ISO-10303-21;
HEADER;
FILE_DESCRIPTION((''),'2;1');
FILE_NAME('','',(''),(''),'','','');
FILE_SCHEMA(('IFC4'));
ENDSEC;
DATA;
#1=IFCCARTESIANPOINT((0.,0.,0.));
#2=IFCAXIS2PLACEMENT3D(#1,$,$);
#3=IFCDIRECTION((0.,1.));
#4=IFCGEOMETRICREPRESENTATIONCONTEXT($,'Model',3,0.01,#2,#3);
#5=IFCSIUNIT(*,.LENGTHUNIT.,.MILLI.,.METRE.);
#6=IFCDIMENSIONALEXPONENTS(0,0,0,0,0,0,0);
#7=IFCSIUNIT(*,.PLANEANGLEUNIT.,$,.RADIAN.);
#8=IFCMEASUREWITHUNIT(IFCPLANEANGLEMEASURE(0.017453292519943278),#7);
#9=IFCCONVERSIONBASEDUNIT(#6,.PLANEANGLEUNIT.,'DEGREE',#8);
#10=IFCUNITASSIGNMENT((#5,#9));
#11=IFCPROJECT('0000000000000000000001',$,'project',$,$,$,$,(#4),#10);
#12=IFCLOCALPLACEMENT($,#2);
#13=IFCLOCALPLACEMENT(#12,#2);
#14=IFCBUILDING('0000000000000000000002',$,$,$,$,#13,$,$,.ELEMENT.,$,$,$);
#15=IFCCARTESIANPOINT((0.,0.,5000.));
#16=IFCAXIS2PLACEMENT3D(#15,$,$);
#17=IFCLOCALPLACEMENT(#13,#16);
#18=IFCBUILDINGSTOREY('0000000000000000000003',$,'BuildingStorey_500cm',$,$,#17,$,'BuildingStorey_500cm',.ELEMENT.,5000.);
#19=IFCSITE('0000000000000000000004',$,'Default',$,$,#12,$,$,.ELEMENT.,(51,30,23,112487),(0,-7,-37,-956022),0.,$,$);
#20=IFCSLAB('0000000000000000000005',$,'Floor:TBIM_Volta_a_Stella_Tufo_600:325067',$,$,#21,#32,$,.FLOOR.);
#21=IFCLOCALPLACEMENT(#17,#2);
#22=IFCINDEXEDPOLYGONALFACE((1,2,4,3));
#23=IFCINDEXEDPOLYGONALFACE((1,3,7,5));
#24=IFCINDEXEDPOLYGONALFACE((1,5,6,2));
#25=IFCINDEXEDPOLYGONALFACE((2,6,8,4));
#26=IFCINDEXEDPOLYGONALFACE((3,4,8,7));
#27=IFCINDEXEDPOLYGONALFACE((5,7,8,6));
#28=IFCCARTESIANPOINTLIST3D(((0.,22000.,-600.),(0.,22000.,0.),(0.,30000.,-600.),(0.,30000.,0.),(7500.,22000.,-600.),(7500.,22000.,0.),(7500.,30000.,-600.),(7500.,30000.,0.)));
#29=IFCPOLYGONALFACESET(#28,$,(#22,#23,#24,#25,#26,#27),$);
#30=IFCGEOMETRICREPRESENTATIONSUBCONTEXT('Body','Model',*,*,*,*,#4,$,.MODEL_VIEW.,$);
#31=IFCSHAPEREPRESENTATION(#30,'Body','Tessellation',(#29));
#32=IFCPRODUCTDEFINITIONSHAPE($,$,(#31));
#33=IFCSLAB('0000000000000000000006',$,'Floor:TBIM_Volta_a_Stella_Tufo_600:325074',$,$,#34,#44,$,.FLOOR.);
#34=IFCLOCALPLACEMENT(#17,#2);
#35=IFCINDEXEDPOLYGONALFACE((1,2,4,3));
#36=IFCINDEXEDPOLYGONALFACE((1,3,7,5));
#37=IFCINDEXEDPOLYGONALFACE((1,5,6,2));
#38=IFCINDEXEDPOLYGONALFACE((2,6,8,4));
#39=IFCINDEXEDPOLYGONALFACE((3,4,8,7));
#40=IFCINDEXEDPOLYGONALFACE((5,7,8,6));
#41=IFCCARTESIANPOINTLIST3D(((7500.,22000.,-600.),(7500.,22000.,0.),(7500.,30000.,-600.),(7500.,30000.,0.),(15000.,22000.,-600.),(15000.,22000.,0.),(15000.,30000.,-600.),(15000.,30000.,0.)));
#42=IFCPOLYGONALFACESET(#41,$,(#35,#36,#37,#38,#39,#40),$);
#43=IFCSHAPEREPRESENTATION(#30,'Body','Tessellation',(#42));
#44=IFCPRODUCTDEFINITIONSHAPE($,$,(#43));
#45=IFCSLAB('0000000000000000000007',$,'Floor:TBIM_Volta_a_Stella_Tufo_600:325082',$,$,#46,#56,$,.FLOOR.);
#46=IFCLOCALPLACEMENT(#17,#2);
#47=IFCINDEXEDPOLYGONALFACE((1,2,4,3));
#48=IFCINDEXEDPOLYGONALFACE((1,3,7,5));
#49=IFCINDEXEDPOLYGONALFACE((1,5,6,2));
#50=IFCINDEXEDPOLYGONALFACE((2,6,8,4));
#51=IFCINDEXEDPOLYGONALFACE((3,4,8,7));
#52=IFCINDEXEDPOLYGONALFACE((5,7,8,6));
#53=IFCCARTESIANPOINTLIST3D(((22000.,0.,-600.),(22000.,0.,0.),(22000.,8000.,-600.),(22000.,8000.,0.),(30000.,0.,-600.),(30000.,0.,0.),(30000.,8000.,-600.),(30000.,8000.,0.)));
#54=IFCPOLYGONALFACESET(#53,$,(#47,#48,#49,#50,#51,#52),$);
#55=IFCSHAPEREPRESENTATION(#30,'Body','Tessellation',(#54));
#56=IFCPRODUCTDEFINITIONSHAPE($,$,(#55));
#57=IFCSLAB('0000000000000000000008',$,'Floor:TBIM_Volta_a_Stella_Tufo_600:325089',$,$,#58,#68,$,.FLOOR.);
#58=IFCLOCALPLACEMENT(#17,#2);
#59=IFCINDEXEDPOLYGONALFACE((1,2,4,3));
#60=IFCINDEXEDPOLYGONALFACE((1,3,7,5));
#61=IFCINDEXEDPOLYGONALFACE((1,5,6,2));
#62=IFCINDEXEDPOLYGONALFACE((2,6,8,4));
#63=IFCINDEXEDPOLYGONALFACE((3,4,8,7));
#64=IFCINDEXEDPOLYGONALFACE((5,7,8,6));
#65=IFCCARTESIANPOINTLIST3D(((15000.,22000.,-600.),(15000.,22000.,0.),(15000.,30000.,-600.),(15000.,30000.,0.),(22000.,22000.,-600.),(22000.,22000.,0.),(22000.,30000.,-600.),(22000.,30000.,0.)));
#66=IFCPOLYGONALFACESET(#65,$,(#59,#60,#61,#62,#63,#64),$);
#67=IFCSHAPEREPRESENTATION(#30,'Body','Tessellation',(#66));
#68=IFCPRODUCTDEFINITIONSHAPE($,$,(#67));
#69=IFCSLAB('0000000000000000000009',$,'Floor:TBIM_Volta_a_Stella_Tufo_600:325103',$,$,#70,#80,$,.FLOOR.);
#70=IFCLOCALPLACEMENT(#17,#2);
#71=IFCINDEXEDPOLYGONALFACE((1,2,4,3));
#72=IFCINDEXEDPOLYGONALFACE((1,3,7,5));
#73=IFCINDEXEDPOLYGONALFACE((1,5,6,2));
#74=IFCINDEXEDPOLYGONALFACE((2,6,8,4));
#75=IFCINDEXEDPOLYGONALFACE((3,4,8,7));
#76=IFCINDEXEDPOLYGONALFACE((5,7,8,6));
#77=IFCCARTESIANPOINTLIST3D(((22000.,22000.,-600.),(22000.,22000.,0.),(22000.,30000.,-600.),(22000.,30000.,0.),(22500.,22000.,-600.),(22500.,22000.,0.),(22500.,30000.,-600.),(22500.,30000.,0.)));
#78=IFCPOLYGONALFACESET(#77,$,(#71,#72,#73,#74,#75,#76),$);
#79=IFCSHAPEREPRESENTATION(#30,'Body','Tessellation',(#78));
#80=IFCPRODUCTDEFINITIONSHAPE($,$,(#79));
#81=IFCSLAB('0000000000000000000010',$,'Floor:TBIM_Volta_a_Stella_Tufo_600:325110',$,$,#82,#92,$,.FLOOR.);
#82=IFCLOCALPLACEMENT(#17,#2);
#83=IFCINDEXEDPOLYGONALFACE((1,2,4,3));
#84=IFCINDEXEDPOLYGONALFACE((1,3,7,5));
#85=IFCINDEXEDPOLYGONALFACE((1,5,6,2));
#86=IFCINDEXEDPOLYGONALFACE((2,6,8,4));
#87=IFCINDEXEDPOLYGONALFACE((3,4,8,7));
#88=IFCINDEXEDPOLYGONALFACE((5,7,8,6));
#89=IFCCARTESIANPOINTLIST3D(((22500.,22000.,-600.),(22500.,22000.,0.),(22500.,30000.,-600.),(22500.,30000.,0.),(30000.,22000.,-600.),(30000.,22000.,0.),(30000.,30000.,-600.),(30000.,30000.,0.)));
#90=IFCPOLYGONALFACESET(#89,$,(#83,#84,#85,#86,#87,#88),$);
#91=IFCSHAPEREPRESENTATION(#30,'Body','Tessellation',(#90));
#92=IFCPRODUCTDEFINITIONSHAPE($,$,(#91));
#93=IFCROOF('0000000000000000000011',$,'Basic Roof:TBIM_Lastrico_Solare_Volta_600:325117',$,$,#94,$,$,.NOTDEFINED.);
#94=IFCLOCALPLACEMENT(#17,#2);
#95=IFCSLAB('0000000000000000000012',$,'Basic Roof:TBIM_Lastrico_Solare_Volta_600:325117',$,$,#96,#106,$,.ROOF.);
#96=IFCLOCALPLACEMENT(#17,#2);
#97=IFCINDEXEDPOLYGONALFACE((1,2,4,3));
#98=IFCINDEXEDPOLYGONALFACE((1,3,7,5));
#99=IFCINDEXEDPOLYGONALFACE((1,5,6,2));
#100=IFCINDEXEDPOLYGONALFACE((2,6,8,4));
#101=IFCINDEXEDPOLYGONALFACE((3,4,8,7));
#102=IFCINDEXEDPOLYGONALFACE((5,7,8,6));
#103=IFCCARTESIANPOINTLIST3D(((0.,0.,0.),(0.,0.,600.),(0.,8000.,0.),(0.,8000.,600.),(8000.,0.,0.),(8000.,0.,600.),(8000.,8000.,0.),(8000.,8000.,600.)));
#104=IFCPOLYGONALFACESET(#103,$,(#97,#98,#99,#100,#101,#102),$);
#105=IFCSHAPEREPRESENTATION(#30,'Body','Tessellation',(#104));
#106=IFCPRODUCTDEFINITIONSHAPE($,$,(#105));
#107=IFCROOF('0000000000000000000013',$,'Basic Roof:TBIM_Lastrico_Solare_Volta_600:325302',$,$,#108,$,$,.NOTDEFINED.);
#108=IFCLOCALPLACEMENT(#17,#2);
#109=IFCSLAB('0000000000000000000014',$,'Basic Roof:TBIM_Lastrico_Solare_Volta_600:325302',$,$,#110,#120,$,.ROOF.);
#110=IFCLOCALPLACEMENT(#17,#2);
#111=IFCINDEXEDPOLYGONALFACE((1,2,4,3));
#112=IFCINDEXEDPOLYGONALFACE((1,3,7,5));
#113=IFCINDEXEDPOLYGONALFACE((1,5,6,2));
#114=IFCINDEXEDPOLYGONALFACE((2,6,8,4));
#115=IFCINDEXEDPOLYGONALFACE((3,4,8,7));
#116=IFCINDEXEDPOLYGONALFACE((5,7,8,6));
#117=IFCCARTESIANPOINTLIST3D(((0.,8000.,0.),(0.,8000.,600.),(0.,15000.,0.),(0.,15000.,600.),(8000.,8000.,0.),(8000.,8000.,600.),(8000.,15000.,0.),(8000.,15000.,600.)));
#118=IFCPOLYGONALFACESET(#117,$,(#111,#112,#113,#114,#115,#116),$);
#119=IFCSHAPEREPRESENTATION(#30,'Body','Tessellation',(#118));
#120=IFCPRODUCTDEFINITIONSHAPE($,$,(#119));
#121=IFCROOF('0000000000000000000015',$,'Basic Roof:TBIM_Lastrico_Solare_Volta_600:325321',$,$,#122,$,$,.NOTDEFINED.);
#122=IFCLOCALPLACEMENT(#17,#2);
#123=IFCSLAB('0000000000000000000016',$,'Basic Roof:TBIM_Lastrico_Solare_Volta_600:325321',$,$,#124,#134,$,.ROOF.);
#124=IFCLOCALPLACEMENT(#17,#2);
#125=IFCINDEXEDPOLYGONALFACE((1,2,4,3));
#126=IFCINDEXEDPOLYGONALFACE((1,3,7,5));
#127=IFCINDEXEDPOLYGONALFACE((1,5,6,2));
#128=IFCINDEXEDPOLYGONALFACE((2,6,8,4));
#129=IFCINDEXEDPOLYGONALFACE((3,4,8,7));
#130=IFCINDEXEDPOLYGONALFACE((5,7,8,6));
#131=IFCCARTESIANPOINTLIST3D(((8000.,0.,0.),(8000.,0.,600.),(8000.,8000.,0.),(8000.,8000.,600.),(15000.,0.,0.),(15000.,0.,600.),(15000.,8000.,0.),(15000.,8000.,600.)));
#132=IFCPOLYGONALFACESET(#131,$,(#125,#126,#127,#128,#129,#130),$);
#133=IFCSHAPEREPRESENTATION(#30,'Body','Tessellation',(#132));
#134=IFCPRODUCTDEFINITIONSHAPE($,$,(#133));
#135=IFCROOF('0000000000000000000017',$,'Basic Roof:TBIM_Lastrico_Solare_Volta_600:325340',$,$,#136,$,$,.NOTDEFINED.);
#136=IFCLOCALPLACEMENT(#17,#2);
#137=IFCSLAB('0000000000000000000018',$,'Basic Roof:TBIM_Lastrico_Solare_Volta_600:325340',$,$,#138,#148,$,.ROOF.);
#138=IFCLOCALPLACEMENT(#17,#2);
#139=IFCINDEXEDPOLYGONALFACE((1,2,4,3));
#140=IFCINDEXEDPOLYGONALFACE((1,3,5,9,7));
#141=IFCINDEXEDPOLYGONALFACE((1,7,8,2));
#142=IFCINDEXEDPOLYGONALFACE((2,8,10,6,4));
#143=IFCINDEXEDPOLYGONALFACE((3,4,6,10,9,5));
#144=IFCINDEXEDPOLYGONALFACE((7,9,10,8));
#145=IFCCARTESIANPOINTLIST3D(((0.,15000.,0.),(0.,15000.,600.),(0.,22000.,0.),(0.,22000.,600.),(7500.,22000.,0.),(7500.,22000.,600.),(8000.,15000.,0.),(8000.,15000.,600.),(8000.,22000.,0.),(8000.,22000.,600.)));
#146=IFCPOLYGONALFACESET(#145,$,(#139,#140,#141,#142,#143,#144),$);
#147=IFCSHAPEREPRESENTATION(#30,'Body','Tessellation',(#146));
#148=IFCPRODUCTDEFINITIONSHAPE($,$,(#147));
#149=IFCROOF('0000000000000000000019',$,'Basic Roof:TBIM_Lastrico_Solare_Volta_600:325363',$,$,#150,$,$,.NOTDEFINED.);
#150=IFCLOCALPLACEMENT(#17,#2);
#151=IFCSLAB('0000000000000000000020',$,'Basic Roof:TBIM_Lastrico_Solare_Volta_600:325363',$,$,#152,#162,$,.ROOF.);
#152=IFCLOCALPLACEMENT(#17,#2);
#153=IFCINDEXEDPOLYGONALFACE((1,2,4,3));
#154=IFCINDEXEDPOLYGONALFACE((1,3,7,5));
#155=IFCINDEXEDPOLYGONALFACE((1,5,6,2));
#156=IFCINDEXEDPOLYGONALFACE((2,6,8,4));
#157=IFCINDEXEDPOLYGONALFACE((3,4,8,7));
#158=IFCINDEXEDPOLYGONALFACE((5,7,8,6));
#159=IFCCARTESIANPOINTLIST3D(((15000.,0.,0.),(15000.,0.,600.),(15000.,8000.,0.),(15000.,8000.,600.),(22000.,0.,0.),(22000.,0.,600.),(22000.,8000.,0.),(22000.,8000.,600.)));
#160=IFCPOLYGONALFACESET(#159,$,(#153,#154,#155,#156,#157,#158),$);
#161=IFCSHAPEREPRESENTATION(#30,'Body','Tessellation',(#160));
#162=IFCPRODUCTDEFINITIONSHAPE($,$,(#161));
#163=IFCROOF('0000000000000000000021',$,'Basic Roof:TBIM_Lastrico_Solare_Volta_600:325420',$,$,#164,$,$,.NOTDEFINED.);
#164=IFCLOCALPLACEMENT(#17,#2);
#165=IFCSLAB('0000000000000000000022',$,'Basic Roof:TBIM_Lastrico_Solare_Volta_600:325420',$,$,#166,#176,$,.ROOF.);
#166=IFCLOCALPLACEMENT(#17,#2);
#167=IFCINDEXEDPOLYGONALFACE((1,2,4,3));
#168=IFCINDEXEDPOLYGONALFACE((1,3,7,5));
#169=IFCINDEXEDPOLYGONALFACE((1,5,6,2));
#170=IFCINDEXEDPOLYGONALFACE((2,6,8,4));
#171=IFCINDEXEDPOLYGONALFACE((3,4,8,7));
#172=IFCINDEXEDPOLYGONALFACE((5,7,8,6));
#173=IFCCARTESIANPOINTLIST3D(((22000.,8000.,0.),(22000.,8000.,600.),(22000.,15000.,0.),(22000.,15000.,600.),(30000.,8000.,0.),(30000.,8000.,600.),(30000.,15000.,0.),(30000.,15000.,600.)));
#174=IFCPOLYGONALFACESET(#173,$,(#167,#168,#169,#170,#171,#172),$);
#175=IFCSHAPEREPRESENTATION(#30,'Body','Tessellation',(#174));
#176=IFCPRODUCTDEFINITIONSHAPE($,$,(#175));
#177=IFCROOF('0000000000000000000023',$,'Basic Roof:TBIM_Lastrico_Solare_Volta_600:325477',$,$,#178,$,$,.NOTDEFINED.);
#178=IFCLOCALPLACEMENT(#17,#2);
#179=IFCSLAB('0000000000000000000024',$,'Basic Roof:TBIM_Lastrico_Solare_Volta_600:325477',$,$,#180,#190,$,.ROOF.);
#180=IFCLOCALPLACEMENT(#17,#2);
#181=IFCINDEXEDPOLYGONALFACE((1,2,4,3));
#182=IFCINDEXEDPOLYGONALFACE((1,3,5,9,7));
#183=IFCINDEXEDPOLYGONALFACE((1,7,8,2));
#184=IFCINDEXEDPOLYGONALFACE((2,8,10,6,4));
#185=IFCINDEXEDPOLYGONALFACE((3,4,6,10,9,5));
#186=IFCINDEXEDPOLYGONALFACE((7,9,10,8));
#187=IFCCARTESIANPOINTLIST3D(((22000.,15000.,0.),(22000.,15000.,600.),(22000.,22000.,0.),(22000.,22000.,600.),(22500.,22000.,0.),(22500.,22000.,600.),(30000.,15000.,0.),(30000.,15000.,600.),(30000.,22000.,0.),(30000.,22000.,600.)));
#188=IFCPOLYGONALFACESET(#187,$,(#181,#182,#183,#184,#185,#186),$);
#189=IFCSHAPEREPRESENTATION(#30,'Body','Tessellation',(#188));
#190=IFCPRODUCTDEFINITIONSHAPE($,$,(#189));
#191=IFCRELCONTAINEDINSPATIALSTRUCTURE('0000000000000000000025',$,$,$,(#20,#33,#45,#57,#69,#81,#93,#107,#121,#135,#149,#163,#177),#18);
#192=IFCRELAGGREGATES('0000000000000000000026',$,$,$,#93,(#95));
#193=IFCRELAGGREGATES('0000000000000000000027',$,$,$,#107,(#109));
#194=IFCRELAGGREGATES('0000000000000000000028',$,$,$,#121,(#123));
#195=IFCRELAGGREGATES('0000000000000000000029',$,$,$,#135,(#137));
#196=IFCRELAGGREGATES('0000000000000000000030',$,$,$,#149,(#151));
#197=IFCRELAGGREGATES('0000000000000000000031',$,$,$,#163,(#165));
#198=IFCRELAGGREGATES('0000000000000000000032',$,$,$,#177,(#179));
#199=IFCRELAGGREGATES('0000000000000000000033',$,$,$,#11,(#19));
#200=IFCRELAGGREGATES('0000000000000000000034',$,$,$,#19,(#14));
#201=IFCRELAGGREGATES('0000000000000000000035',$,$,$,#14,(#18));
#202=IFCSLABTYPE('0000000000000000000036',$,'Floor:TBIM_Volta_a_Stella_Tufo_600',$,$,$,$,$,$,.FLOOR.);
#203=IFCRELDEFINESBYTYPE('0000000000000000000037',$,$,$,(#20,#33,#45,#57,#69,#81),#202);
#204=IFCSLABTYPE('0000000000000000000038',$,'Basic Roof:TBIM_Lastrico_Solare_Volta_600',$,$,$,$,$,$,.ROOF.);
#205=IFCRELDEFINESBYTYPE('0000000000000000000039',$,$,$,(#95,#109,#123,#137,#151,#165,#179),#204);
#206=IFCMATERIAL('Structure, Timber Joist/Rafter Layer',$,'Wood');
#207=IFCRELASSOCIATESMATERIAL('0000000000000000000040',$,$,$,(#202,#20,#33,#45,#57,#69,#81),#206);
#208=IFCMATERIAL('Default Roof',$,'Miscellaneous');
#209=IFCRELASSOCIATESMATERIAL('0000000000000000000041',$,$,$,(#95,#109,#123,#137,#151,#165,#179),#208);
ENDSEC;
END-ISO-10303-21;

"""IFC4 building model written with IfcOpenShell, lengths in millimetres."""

from ifc_helpers import new_model, entity, si_unit, converted_unit, direction, frame, origin, place, context, subcontext, project, spatial, indexed_curve, outline, extrude, material, type_object, element, aggregate, save


model = new_model("IFC4")

# Units and contexts
model_context = context("Model", 3, precision=0.01, world=origin(), true_north=direction((0.0, 1.0)))
body_context = subcontext(model_context, "Body", "Model", "MODEL_VIEW")
ifc_project = project(units=[si_unit("LENGTHUNIT", "METRE", prefix="MILLI"), converted_unit("PLANEANGLEUNIT", "DEGREE", entity("IfcPlaneAngleMeasure", 0.017453292519943278), si_unit("PLANEANGLEUNIT", "RADIAN"), dimensions=[0, 0, 0, 0, 0, 0, 0])], contexts=[model_context])

# Site, building, storey
site_placement = place(None, origin())
site = spatial("IfcSite", under=ifc_project, at=site_placement, Name="Default", CompositionType="ELEMENT", RefLatitude=(51, 30, 23, 112487), RefLongitude=(0, -7, -37, -956022), RefElevation=0.0)
building_placement = place(site_placement, origin())
building = spatial("IfcBuilding", under=site, at=building_placement, CompositionType="ELEMENT")
storey_placement = place(building_placement, frame((0.0, 0.0, 5000.0)))
storey = spatial("IfcBuildingStorey", under=building, at=storey_placement, Name="BuildingStorey_500cm", LongName="BuildingStorey_500cm", CompositionType="ELEMENT", Elevation=5000.0)

# Slabs
ifc_material_1 = material(Name="Structure, Timber Joist/Rafter Layer", Category="Wood")
slab_type_1 = type_object("IfcSlabType", Name="Floor:TBIM_Volta_a_Stella_Tufo_600", PredefinedType="FLOOR", material=ifc_material_1)
slab_1_placement = place(storey_placement, origin())
element("IfcSlab", 1, at=slab_1_placement, inside=storey, type_object=slab_type_1, material=ifc_material_1, Name="Floor:TBIM_Volta_a_Stella_Tufo_600:325067", PredefinedType="FLOOR", context=body_context, shape_type="SweptSolid", body=[
    extrude(outline(indexed_curve([(-4000.0, -3750.0), (4000.0, -3750.0), (4000.0, 3750.0), (-4000.0, 3750.0), (-4000.0, -3750.0)], self_intersect=False)), frame((3750.0, 26000.0, 0.0), z_axis=(0.0, 0.0, -1.0), x_axis=(0.0, 1.0, 0.0)), (0.0, 0.0, 1.0), 600.0),
])
slab_2_placement = place(storey_placement, origin())
element("IfcSlab", 2, at=slab_2_placement, inside=storey, type_object=slab_type_1, material=ifc_material_1, Name="Floor:TBIM_Volta_a_Stella_Tufo_600:325074", PredefinedType="FLOOR", context=body_context, shape_type="SweptSolid", body=[
    extrude(outline(indexed_curve([(-4000.0, -3750.0), (4000.0, -3750.0), (4000.0, 3750.0), (-4000.0, 3750.0), (-4000.0, -3750.0)], self_intersect=False)), frame((11250.0, 26000.0, 0.0), z_axis=(0.0, 0.0, -1.0), x_axis=(0.0, 1.0, 0.0)), (0.0, 0.0, 1.0), 600.0),
])
slab_3_placement = place(storey_placement, origin())
element("IfcSlab", 3, at=slab_3_placement, inside=storey, type_object=slab_type_1, material=ifc_material_1, Name="Floor:TBIM_Volta_a_Stella_Tufo_600:325082", PredefinedType="FLOOR", context=body_context, shape_type="SweptSolid", body=[
    extrude(outline(indexed_curve([(-4000.0, -4000.0), (4000.0, -4000.0), (4000.0, 4000.0), (-4000.0, 4000.0), (-4000.0, -4000.0)], self_intersect=False)), frame((26000.0, 4000.0, 0.0), z_axis=(0.0, 0.0, -1.0), x_axis=(0.0, 1.0, 0.0)), (0.0, 0.0, 1.0), 600.0),
])
slab_4_placement = place(storey_placement, origin())
element("IfcSlab", 4, at=slab_4_placement, inside=storey, type_object=slab_type_1, material=ifc_material_1, Name="Floor:TBIM_Volta_a_Stella_Tufo_600:325089", PredefinedType="FLOOR", context=body_context, shape_type="SweptSolid", body=[
    extrude(outline(indexed_curve([(-4000.0, -3500.0), (4000.0, -3500.0), (4000.0, 3500.0), (-4000.0, 3500.0), (-4000.0, -3500.0)], self_intersect=False)), frame((18500.0, 26000.0, 0.0), z_axis=(0.0, 0.0, -1.0), x_axis=(0.0, 1.0, 0.0)), (0.0, 0.0, 1.0), 600.0),
])
slab_5_placement = place(storey_placement, origin())
element("IfcSlab", 5, at=slab_5_placement, inside=storey, type_object=slab_type_1, material=ifc_material_1, Name="Floor:TBIM_Volta_a_Stella_Tufo_600:325103", PredefinedType="FLOOR", context=body_context, shape_type="SweptSolid", body=[
    extrude(outline(indexed_curve([(-4000.0, -250.0), (4000.0, -250.0), (4000.0, 250.0), (-4000.0, 250.0), (-4000.0, -250.0)], self_intersect=False)), frame((22250.0, 26000.0, 0.0), z_axis=(0.0, 0.0, -1.0), x_axis=(0.0, 1.0, 0.0)), (0.0, 0.0, 1.0), 600.0),
])
slab_6_placement = place(storey_placement, origin())
element("IfcSlab", 6, at=slab_6_placement, inside=storey, type_object=slab_type_1, material=ifc_material_1, Name="Floor:TBIM_Volta_a_Stella_Tufo_600:325110", PredefinedType="FLOOR", context=body_context, shape_type="SweptSolid", body=[
    extrude(outline(indexed_curve([(-4000.0, -3750.0), (4000.0, -3750.0), (4000.0, 3750.0), (-4000.0, 3750.0), (-4000.0, -3750.0)], self_intersect=False)), frame((26250.0, 26000.0, 0.0), z_axis=(0.0, 0.0, -1.0), x_axis=(0.0, 1.0, 0.0)), (0.0, 0.0, 1.0), 600.0),
])

# Roofs, slabs
roof_1_placement = place(storey_placement, origin())
roof_1 = element("IfcRoof", 7, at=roof_1_placement, inside=storey, Name="Basic Roof:TBIM_Lastrico_Solare_Volta_600:325117", PredefinedType="NOTDEFINED")
ifc_material_2 = material(Name="Default Roof", Category="Miscellaneous")
slab_type_2 = type_object("IfcSlabType", Name="Basic Roof:TBIM_Lastrico_Solare_Volta_600", PredefinedType="ROOF")
slab_7_placement = place(roof_1_placement, origin())
slab_7 = element("IfcSlab", 8, at=slab_7_placement, type_object=slab_type_2, material=ifc_material_2, Name="Basic Roof:TBIM_Lastrico_Solare_Volta_600:325117", PredefinedType="ROOF", context=body_context, shape_type="SweptSolid", body=[
    extrude(outline(indexed_curve([(-4000.0, 4000.0), (-4000.0, -4000.0), (4000.0, -4000.0), (4000.0, 4000.0), (-4000.0, 4000.0)], self_intersect=False)), frame((4000.0, 4000.0, 0.0)), (0.0, 0.0, 1.0), 600.0),
])
aggregate(roof_1, [slab_7])
roof_2_placement = place(storey_placement, frame((0.0, 8000.0, 0.0)))
roof_2 = element("IfcRoof", 9, at=roof_2_placement, inside=storey, Name="Basic Roof:TBIM_Lastrico_Solare_Volta_600:325302", PredefinedType="NOTDEFINED")
slab_8_placement = place(roof_2_placement, origin())
slab_8 = element("IfcSlab", 10, at=slab_8_placement, type_object=slab_type_2, material=ifc_material_2, Name="Basic Roof:TBIM_Lastrico_Solare_Volta_600:325302", PredefinedType="ROOF", context=body_context, shape_type="SweptSolid", body=[
    extrude(outline(indexed_curve([(-4000.0, 3500.0), (-4000.0, -3500.0), (4000.0, -3500.0), (4000.0, 3500.0), (-4000.0, 3500.0)], self_intersect=False)), frame((4000.0, 3500.0, 0.0)), (0.0, 0.0, 1.0), 600.0),
])
aggregate(roof_2, [slab_8])
roof_3_placement = place(storey_placement, frame((8000.0, 0.0, 0.0)))
roof_3 = element("IfcRoof", 11, at=roof_3_placement, inside=storey, Name="Basic Roof:TBIM_Lastrico_Solare_Volta_600:325321", PredefinedType="NOTDEFINED")
slab_9_placement = place(roof_3_placement, origin())
slab_9 = element("IfcSlab", 12, at=slab_9_placement, type_object=slab_type_2, material=ifc_material_2, Name="Basic Roof:TBIM_Lastrico_Solare_Volta_600:325321", PredefinedType="ROOF", context=body_context, shape_type="SweptSolid", body=[
    extrude(outline(indexed_curve([(-3500.0, 4000.0), (-3500.0, -4000.0), (3500.0, -4000.0), (3500.0, 4000.0), (-3500.0, 4000.0)], self_intersect=False)), frame((3500.0, 4000.0, 0.0)), (0.0, 0.0, 1.0), 600.0),
])
aggregate(roof_3, [slab_9])
roof_4_placement = place(storey_placement, frame((0.0, 15000.0, 0.0)))
roof_4 = element("IfcRoof", 13, at=roof_4_placement, inside=storey, Name="Basic Roof:TBIM_Lastrico_Solare_Volta_600:325340", PredefinedType="NOTDEFINED")
slab_10_placement = place(roof_4_placement, origin())
slab_10 = element("IfcSlab", 14, at=slab_10_placement, type_object=slab_type_2, material=ifc_material_2, Name="Basic Roof:TBIM_Lastrico_Solare_Volta_600:325340", PredefinedType="ROOF", context=body_context, shape_type="SweptSolid", body=[
    extrude(outline(indexed_curve([(4000.0, 3500.0), (3500.0, 3500.0), (-4000.0, 3500.0), (-4000.0, -3500.0), (4000.0, -3500.0), (4000.0, 3500.0)], self_intersect=False)), frame((4000.0, 3500.0, 0.0)), (0.0, 0.0, 1.0), 600.0),
])
aggregate(roof_4, [slab_10])
roof_5_placement = place(storey_placement, frame((15000.0, 0.0, 0.0)))
roof_5 = element("IfcRoof", 15, at=roof_5_placement, inside=storey, Name="Basic Roof:TBIM_Lastrico_Solare_Volta_600:325363", PredefinedType="NOTDEFINED")
slab_11_placement = place(roof_5_placement, origin())
slab_11 = element("IfcSlab", 16, at=slab_11_placement, type_object=slab_type_2, material=ifc_material_2, Name="Basic Roof:TBIM_Lastrico_Solare_Volta_600:325363", PredefinedType="ROOF", context=body_context, shape_type="SweptSolid", body=[
    extrude(outline(indexed_curve([(-3500.0, 4000.0), (-3500.0, -4000.0), (3500.0, -4000.0), (3500.0, 4000.0), (-3500.0, 4000.0)], self_intersect=False)), frame((3500.0, 4000.0, 0.0)), (0.0, 0.0, 1.0), 600.0),
])
aggregate(roof_5, [slab_11])
roof_6_placement = place(storey_placement, frame((22000.0, 8000.0, 0.0)))
roof_6 = element("IfcRoof", 17, at=roof_6_placement, inside=storey, Name="Basic Roof:TBIM_Lastrico_Solare_Volta_600:325420", PredefinedType="NOTDEFINED")
slab_12_placement = place(roof_6_placement, origin())
slab_12 = element("IfcSlab", 18, at=slab_12_placement, type_object=slab_type_2, material=ifc_material_2, Name="Basic Roof:TBIM_Lastrico_Solare_Volta_600:325420", PredefinedType="ROOF", context=body_context, shape_type="SweptSolid", body=[
    extrude(outline(indexed_curve([(-4000.0, 3500.0), (-4000.0, -3500.0), (4000.0, -3500.0), (4000.0, 3500.0), (-4000.0, 3500.0)], self_intersect=False)), frame((4000.0, 3500.0, 0.0)), (0.0, 0.0, 1.0), 600.0),
])
aggregate(roof_6, [slab_12])
roof_7_placement = place(storey_placement, frame((22000.0, 15000.0, 0.0)))
roof_7 = element("IfcRoof", 19, at=roof_7_placement, inside=storey, Name="Basic Roof:TBIM_Lastrico_Solare_Volta_600:325477", PredefinedType="NOTDEFINED")
slab_13_placement = place(roof_7_placement, origin())
slab_13 = element("IfcSlab", 20, at=slab_13_placement, type_object=slab_type_2, material=ifc_material_2, Name="Basic Roof:TBIM_Lastrico_Solare_Volta_600:325477", PredefinedType="ROOF", context=body_context, shape_type="SweptSolid", body=[
    extrude(outline(indexed_curve([(4000.0, 3500.0), (-3500.0, 3500.0), (-4000.0, 3500.0), (-4000.0, -3500.0), (4000.0, -3500.0), (4000.0, 3500.0)], self_intersect=False)), frame((4000.0, 3500.0, 0.0)), (0.0, 0.0, 1.0), 600.0),
])
aggregate(roof_7, [slab_13])

save(model, "model.ifc")
